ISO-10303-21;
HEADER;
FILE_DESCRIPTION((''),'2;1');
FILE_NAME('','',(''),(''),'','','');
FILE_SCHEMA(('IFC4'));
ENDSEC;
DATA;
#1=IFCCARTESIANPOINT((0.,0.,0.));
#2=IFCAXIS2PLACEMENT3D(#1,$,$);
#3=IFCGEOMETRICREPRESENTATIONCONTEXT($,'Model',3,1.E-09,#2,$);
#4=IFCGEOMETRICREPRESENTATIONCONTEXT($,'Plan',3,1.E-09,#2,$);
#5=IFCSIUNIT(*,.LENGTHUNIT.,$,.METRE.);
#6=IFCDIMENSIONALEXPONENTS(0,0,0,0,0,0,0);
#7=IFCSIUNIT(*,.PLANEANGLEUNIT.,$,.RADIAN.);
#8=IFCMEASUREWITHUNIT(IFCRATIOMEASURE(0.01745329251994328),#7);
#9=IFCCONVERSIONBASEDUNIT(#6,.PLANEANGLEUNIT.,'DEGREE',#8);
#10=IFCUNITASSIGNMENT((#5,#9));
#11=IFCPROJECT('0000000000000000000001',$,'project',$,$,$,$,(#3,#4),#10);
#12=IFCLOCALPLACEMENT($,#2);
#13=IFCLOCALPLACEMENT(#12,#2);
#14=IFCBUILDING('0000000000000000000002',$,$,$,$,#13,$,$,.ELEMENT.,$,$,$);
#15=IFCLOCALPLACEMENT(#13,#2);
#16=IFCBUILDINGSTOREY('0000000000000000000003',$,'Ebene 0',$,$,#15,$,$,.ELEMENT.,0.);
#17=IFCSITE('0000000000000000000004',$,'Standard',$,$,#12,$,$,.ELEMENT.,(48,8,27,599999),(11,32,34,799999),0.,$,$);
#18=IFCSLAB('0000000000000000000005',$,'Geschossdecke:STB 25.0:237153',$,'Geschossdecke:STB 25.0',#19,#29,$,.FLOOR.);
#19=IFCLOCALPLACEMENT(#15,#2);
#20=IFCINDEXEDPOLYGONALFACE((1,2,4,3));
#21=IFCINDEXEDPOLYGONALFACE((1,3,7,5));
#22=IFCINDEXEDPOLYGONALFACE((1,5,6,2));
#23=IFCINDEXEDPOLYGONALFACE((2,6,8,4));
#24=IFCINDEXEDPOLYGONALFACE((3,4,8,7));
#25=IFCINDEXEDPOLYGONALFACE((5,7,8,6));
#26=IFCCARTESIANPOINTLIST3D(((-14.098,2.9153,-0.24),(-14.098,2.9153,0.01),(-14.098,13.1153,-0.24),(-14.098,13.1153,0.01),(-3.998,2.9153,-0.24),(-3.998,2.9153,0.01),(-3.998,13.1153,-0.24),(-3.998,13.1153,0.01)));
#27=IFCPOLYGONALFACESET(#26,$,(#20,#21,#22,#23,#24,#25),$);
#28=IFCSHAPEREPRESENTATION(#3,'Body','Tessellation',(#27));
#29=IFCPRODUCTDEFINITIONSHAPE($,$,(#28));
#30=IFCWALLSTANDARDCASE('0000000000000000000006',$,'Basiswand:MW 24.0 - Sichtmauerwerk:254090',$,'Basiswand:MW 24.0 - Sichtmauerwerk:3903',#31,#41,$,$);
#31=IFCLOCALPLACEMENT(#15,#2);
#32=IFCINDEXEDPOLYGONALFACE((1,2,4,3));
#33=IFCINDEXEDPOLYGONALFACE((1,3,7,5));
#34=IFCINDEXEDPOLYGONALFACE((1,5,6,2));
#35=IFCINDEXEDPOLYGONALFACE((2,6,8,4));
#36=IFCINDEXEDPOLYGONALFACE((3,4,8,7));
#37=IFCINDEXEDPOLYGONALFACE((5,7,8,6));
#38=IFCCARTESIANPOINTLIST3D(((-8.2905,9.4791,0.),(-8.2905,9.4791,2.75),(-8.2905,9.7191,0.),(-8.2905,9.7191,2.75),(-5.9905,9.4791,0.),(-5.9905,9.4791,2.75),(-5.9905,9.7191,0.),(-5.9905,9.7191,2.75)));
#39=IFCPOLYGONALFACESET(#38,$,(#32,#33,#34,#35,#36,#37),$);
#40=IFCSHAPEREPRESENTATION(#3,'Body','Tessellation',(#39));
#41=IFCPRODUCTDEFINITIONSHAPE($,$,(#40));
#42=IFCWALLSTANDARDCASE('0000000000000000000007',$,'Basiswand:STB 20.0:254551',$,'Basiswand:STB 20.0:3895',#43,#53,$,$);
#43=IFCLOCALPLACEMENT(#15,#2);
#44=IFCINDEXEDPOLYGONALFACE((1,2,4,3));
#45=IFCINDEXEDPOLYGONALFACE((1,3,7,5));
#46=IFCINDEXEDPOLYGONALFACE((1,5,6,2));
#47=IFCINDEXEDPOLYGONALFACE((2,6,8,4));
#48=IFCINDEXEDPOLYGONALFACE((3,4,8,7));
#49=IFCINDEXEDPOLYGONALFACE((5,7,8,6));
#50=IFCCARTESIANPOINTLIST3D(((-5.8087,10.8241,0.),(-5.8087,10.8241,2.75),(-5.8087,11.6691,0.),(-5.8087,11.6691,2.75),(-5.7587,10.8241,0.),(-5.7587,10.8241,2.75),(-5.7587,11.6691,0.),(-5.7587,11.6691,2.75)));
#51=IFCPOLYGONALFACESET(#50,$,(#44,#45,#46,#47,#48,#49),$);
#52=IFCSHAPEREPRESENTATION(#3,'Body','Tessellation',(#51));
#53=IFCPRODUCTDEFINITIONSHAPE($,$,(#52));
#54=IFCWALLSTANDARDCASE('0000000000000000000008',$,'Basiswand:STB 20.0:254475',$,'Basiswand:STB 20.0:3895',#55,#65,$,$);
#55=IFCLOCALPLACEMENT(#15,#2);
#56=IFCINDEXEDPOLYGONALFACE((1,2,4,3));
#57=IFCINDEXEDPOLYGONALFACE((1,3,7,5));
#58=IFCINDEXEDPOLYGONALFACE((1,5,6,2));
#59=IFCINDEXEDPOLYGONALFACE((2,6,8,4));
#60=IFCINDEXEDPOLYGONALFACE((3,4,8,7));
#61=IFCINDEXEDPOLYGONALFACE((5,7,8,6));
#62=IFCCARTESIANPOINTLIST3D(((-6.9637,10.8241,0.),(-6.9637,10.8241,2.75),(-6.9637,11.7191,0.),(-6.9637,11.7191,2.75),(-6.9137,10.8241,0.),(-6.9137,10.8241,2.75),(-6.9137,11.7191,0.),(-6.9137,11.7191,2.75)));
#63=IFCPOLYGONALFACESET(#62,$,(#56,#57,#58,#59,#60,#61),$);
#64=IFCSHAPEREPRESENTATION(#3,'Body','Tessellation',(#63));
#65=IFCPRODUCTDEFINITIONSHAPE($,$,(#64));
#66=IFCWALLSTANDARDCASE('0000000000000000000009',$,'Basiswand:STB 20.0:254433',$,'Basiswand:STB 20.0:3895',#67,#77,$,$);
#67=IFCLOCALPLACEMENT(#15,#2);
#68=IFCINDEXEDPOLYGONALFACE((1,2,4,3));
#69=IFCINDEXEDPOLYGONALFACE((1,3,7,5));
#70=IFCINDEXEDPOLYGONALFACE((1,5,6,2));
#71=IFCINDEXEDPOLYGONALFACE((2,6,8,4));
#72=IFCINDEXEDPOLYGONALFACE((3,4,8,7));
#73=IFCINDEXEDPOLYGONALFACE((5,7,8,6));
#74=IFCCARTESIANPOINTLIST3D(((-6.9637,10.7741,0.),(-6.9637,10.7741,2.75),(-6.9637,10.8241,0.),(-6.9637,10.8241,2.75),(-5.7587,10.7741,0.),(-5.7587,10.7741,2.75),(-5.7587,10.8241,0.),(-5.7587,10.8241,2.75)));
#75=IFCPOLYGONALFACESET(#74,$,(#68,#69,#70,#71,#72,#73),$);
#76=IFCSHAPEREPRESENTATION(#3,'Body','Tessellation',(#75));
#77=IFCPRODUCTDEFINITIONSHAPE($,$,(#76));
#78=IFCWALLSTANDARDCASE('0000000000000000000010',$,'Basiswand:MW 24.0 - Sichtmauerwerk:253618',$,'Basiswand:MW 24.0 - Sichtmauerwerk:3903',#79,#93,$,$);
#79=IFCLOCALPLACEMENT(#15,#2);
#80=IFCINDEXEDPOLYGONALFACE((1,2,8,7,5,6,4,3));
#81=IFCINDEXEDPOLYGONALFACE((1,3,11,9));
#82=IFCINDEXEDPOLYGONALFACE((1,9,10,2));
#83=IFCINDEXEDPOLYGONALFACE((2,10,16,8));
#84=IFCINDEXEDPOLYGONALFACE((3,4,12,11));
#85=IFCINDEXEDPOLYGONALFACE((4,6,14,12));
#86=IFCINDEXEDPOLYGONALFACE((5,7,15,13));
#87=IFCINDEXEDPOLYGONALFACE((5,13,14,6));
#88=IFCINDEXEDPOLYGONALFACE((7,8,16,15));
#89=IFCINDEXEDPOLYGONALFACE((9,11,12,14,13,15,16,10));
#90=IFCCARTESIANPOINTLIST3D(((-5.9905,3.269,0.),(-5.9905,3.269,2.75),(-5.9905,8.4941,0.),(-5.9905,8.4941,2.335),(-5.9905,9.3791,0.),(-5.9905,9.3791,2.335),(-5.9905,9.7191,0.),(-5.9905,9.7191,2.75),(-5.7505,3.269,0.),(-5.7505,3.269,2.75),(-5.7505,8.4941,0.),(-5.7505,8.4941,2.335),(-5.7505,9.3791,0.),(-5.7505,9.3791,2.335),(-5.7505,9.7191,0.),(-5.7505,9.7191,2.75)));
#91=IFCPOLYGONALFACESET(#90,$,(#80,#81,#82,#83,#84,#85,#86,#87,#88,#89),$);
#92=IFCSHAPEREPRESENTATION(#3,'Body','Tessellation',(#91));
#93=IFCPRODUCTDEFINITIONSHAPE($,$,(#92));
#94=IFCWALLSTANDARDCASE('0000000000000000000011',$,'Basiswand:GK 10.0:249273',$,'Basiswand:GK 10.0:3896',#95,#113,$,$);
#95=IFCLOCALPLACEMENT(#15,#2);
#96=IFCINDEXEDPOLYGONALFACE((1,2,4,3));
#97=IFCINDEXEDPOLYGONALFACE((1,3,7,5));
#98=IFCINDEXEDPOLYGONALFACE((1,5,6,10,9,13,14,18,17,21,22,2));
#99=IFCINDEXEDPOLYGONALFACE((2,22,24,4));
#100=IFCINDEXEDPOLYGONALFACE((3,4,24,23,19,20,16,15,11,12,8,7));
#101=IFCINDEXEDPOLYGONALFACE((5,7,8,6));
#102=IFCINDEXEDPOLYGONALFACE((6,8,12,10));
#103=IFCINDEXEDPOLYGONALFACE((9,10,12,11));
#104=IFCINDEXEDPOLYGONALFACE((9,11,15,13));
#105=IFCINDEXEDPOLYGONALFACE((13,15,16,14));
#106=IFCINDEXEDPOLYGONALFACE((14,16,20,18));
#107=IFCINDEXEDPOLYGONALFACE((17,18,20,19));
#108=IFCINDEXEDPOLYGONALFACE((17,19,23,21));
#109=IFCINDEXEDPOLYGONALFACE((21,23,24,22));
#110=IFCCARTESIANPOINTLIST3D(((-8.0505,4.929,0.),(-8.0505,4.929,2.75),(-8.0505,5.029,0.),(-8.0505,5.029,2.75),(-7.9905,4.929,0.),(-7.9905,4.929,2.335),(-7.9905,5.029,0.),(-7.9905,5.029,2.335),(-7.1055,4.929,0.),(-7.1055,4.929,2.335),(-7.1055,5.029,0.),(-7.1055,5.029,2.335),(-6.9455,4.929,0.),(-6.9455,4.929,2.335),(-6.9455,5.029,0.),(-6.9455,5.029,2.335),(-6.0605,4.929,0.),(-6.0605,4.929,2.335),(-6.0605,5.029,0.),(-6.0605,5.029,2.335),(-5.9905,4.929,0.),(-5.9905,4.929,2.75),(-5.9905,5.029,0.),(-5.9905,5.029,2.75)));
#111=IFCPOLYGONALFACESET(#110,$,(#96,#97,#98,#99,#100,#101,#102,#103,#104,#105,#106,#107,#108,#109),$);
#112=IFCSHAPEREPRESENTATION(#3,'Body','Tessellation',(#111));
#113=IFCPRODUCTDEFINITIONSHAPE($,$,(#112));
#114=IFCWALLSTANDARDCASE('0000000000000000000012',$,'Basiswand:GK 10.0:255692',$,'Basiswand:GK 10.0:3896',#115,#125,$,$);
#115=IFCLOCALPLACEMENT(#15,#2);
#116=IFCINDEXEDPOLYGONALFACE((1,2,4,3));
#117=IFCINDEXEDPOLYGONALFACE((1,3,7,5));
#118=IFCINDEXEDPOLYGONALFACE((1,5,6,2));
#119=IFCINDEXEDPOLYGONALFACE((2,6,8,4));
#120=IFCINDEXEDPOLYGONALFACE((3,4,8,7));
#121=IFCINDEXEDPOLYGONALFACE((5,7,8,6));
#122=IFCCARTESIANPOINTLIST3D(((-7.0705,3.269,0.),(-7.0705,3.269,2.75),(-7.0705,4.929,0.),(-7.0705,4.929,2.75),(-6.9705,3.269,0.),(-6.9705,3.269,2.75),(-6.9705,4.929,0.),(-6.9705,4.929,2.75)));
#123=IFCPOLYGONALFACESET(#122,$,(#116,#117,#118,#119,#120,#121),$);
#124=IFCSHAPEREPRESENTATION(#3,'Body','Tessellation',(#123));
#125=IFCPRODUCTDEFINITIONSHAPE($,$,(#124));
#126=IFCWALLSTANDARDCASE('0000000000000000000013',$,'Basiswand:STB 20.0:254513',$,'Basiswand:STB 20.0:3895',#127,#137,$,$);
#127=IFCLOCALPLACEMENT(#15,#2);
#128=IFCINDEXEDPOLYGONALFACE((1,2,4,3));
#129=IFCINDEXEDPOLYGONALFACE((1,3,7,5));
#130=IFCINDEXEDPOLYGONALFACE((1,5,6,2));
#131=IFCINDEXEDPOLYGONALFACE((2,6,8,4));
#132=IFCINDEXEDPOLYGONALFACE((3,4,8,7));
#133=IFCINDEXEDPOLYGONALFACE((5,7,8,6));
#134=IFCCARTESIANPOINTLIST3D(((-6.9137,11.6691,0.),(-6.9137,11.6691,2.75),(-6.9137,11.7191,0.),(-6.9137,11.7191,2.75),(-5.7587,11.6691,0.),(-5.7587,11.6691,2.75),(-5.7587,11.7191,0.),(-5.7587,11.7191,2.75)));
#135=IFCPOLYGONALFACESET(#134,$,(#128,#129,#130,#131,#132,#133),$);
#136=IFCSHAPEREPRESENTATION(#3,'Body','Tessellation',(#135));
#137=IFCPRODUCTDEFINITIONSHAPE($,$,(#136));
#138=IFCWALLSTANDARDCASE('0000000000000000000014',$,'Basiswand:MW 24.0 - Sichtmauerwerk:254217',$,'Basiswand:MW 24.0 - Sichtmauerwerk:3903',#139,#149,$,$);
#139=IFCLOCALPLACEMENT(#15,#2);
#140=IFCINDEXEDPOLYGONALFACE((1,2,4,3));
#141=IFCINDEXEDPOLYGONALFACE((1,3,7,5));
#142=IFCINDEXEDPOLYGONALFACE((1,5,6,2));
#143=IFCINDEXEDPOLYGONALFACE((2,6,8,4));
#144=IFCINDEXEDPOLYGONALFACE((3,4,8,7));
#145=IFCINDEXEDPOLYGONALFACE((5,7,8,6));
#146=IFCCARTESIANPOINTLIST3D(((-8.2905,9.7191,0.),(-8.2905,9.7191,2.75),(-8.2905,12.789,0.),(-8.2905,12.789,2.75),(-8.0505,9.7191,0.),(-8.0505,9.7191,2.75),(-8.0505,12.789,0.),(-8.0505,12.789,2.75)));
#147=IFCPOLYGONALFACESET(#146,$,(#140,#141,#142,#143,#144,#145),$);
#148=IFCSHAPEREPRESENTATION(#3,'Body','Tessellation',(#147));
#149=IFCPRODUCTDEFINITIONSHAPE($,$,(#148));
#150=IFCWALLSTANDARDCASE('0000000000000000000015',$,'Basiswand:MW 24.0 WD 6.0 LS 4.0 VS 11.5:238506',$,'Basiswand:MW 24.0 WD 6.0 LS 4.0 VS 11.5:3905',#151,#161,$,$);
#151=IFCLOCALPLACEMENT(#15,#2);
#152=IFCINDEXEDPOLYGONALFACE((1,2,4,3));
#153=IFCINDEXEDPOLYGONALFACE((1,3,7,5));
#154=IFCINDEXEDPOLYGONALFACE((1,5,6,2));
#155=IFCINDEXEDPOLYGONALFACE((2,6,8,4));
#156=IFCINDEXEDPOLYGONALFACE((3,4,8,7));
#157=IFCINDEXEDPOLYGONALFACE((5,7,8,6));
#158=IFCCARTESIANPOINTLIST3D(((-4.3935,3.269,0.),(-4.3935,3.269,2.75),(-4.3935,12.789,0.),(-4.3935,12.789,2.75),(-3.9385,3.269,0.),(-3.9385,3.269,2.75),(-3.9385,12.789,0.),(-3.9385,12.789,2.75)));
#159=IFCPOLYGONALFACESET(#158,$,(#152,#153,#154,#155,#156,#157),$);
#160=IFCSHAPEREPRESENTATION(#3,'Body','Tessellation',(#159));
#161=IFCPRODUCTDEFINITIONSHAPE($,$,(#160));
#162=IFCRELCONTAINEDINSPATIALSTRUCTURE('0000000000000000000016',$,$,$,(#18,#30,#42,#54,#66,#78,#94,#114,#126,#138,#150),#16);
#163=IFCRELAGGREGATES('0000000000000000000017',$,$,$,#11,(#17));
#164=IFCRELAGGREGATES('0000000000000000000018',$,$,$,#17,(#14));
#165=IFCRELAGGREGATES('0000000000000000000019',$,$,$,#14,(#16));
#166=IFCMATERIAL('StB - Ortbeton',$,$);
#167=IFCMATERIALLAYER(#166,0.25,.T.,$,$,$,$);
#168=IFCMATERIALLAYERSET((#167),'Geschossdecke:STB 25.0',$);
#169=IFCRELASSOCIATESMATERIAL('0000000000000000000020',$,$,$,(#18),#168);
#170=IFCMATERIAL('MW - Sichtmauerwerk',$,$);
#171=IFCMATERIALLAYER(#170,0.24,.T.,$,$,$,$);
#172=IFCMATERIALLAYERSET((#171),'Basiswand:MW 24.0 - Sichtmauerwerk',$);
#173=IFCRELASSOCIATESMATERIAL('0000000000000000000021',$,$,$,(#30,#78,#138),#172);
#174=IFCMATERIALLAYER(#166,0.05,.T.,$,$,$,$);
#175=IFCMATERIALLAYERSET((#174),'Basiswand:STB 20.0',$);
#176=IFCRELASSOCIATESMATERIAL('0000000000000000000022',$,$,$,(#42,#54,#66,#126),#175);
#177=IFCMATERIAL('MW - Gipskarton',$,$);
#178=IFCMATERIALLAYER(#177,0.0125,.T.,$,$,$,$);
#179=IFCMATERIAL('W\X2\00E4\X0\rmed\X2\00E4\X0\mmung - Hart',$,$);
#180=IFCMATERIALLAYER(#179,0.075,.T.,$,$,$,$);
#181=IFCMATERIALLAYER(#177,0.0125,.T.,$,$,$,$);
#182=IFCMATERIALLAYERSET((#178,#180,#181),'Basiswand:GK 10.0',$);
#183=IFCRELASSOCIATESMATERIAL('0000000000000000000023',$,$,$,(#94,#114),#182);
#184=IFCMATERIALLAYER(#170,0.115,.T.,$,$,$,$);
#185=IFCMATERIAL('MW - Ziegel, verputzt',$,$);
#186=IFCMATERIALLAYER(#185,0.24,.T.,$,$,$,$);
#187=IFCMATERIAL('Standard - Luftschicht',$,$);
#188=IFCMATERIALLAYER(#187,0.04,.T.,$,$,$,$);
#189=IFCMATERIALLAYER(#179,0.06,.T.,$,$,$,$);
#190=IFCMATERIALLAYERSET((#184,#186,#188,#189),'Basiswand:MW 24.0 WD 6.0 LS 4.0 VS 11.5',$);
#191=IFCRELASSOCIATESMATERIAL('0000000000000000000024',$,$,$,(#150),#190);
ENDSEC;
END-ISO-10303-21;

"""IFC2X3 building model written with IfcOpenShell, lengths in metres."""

from ifc_helpers import new_model, entity, si_unit, converted_unit, frame, frame_2d, origin, place, context, project, spatial, rectangle, extrude, material, layer, layer_set, layer_usage, element, save


model = new_model("IFC2X3")

# Units and contexts
model_context = context("Model", 3, precision=1e-09, world=origin())
plan_context = context("Plan", 3, precision=1e-09, world=origin())
ifc_project = project(units=[si_unit("LENGTHUNIT", "METRE"), converted_unit("PLANEANGLEUNIT", "DEGREE", entity("IfcRatioMeasure", 0.01745329251994328), si_unit("PLANEANGLEUNIT", "RADIAN"), dimensions=[0, 0, 0, 0, 0, 0, 0])], contexts=[model_context, plan_context])

# Site, building, storey
site_placement = place(None, origin())
site = spatial("IfcSite", under=ifc_project, at=site_placement, Name="Standard", CompositionType="ELEMENT", RefLatitude=(48, 8, 27, 599999), RefLongitude=(11, 32, 34, 799999), RefElevation=0.0)
building_placement = place(site_placement, origin())
building = spatial("IfcBuilding", under=site, at=building_placement, CompositionType="ELEMENT")
storey_placement = place(building_placement, origin())
storey = spatial("IfcBuildingStorey", under=building, at=storey_placement, Name="Ebene 0", CompositionType="ELEMENT", Elevation=0.0)

# Slab
ifc_material_1 = material(Name="StB - Ortbeton")
ifc_layer_1 = layer(ifc_material_1, 0.25, ventilated=True)
ifc_layer_set_1 = layer_set([ifc_layer_1], Name="Geschossdecke:STB 25.0")
ifc_layer_usage_1 = layer_usage(ifc_layer_set_1, "AXIS3", "POSITIVE", 0.0)
slab_placement = place(storey_placement, frame((-14.098, 2.9153, -0.24)))
element("IfcSlab", 1, at=slab_placement, inside=storey, material=ifc_layer_usage_1, Name="Geschossdecke:STB 25.0:237153", ObjectType="Geschossdecke:STB 25.0", PredefinedType="FLOOR", context=model_context, shape_type="SweptSolid", body=[
    extrude(rectangle(XDim=10.2, YDim=10.1, at=frame_2d((0.0, 0.0), x_axis=(0.0, -1.0))), frame((5.05, 5.1, 0.25), z_axis=(0.0, 0.0, -1.0), x_axis=(-1.0, 0.0, 0.0)), (0.0, 0.0, 1.0), 0.25),
])

# Walls
ifc_material_2 = material(Name="MW - Sichtmauerwerk")
ifc_layer_2 = layer(ifc_material_2, 0.24, ventilated=True)
ifc_layer_set_2 = layer_set([ifc_layer_2], Name="Basiswand:MW 24.0 - Sichtmauerwerk")
ifc_layer_usage_2 = layer_usage(ifc_layer_set_2, "AXIS2", "NEGATIVE", 0.12)
wall_1_placement = place(storey_placement, frame((-5.9905, 9.5991, 0.0), z_axis=(0.0, 0.0, 1.0), x_axis=(-1.0, 0.0, 0.0)))
element("IfcWallStandardCase", 2, at=wall_1_placement, inside=storey, material=ifc_layer_usage_2, Name="Basiswand:MW 24.0 - Sichtmauerwerk:254090", ObjectType="Basiswand:MW 24.0 - Sichtmauerwerk:3903", context=model_context, shape_type="SweptSolid", body=[
    extrude(rectangle(XDim=2.3, YDim=0.24, at=frame_2d((1.15, 0.0), x_axis=(-1.0, 0.0))), origin(), (0.0, 0.0, 1.0), 2.75),
])
ifc_layer_3 = layer(ifc_material_1, 0.05, ventilated=True)
ifc_layer_set_3 = layer_set([ifc_layer_3], Name="Basiswand:STB 20.0")
ifc_layer_usage_3 = layer_usage(ifc_layer_set_3, "AXIS2", "NEGATIVE", 0.025)
wall_2_placement = place(storey_placement, frame((-5.7837, 11.6691, 0.0), z_axis=(0.0, 0.0, 1.0), x_axis=(0.0, -1.0, 0.0)))
element("IfcWallStandardCase", 3, at=wall_2_placement, inside=storey, material=ifc_layer_usage_3, Name="Basiswand:STB 20.0:254551", ObjectType="Basiswand:STB 20.0:3895", context=model_context, shape_type="SweptSolid", body=[
    extrude(rectangle(XDim=0.845, YDim=0.05, at=frame_2d((0.4225, 0.0), x_axis=(-1.0, 0.0))), origin(), (0.0, 0.0, 1.0), 2.75),
])
ifc_layer_usage_4 = layer_usage(ifc_layer_set_3, "AXIS2", "NEGATIVE", 0.025)
wall_3_placement = place(storey_placement, frame((-6.9387, 10.8241, 0.0), z_axis=(0.0, 0.0, 1.0), x_axis=(0.0, 1.0, 0.0)))
element("IfcWallStandardCase", 4, at=wall_3_placement, inside=storey, material=ifc_layer_usage_4, Name="Basiswand:STB 20.0:254475", ObjectType="Basiswand:STB 20.0:3895", context=model_context, shape_type="SweptSolid", body=[
    extrude(rectangle(XDim=0.895, YDim=0.05, at=frame_2d((0.4475, 0.0), x_axis=(-1.0, 0.0))), origin(), (0.0, 0.0, 1.0), 2.75),
])
ifc_layer_usage_5 = layer_usage(ifc_layer_set_3, "AXIS2", "NEGATIVE", 0.025)
wall_4_placement = place(storey_placement, frame((-5.7587, 10.7991, 0.0), z_axis=(0.0, 0.0, 1.0), x_axis=(-1.0, 0.0, 0.0)))
element("IfcWallStandardCase", 5, at=wall_4_placement, inside=storey, material=ifc_layer_usage_5, Name="Basiswand:STB 20.0:254433", ObjectType="Basiswand:STB 20.0:3895", context=model_context, shape_type="SweptSolid", body=[
    extrude(rectangle(XDim=1.205, YDim=0.05, at=frame_2d((0.6025, 0.0), x_axis=(-1.0, 0.0))), origin(), (0.0, 0.0, 1.0), 2.75),
])

# Wall, opening
ifc_layer_usage_6 = layer_usage(ifc_layer_set_2, "AXIS2", "NEGATIVE", 0.12)
wall_5_placement = place(storey_placement, frame((-5.8705, 9.7191, 0.0), z_axis=(0.0, 0.0, 1.0), x_axis=(0.0, -1.0, 0.0)))
wall_5 = element("IfcWallStandardCase", 6, at=wall_5_placement, inside=storey, material=ifc_layer_usage_6, Name="Basiswand:MW 24.0 - Sichtmauerwerk:253618", ObjectType="Basiswand:MW 24.0 - Sichtmauerwerk:3903", context=model_context, shape_type="SweptSolid", body=[
    extrude(rectangle(XDim=6.4501, YDim=0.24, at=frame_2d((3.225, 0.0), x_axis=(-1.0, 0.0))), origin(), (0.0, 0.0, 1.0), 2.75),
])
opening_1_placement = place(wall_5_placement, frame((1.225, 0.12, 0.0)))
element("IfcOpeningElement", 7, at=opening_1_placement, cuts=wall_5, ObjectType="Opening", context=model_context, shape_type="SweptSolid", body=[
    extrude(rectangle(XDim=2.335, YDim=0.885, at=frame_2d((1.1675, 0.4425), x_axis=(1.0, 0.0))), frame((0.0, 0.0, 0.0), z_axis=(0.0, -1.0, 0.0), x_axis=(0.0, 0.0, 1.0)), (0.0, 0.0, 1.0), 0.24),
])

# Wall, openings
ifc_material_3 = material(Name="MW - Gipskarton")
ifc_layer_4 = layer(ifc_material_3, 0.0125, ventilated=True)
ifc_material_4 = material(Name="Wärmedämmung - Hart")
ifc_layer_5 = layer(ifc_material_4, 0.075, ventilated=True)
ifc_layer_6 = layer(ifc_material_3, 0.0125, ventilated=True)
ifc_layer_set_4 = layer_set([ifc_layer_4, ifc_layer_5, ifc_layer_6], Name="Basiswand:GK 10.0")
ifc_layer_usage_7 = layer_usage(ifc_layer_set_4, "AXIS2", "NEGATIVE", 0.05)
wall_6_placement = place(storey_placement, frame((-5.9905, 4.979, 0.0), z_axis=(0.0, 0.0, 1.0), x_axis=(-1.0, 0.0, 0.0)))
wall_6 = element("IfcWallStandardCase", 8, at=wall_6_placement, inside=storey, material=ifc_layer_usage_7, Name="Basiswand:GK 10.0:249273", ObjectType="Basiswand:GK 10.0:3896", context=model_context, shape_type="SweptSolid", body=[
    extrude(rectangle(XDim=2.06, YDim=0.1, at=frame_2d((1.03, 0.0), x_axis=(-1.0, 0.0))), origin(), (0.0, 0.0, 1.0), 2.75),
])
opening_2_placement = place(wall_6_placement, frame((2.0, 0.05, 0.0)))
element("IfcOpeningElement", 9, at=opening_2_placement, cuts=wall_6, ObjectType="Opening", context=model_context, shape_type="SweptSolid", body=[
    extrude(rectangle(XDim=2.335, YDim=0.885, at=frame_2d((1.1675, 0.4425), x_axis=(1.0, 0.0))), frame((0.0, 0.0, 0.0), z_axis=(0.0, -1.0, 0.0), x_axis=(0.0, 0.0, 1.0)), (0.0, 0.0, 1.0), 0.1),
])
opening_3_placement = place(wall_6_placement, frame((0.955, 0.05, 0.0)))
element("IfcOpeningElement", 10, at=opening_3_placement, cuts=wall_6, ObjectType="Opening", context=model_context, shape_type="SweptSolid", body=[
    extrude(rectangle(XDim=2.335, YDim=0.885, at=frame_2d((1.1675, 0.4425), x_axis=(1.0, 0.0))), frame((0.0, 0.0, 0.0), z_axis=(0.0, -1.0, 0.0), x_axis=(0.0, 0.0, 1.0)), (0.0, 0.0, 1.0), 0.1),
])

# Wall
ifc_layer_usage_8 = layer_usage(ifc_layer_set_4, "AXIS2", "NEGATIVE", 0.05)
wall_7_placement = place(storey_placement, frame((-7.0205, 4.929, 0.0), z_axis=(0.0, 0.0, 1.0), x_axis=(0.0, -1.0, 0.0)))
element("IfcWallStandardCase", 11, at=wall_7_placement, inside=storey, material=ifc_layer_usage_8, Name="Basiswand:GK 10.0:255692", ObjectType="Basiswand:GK 10.0:3896", context=model_context, shape_type="SweptSolid", body=[
    extrude(rectangle(XDim=1.66, YDim=0.1, at=frame_2d((0.83, 0.0), x_axis=(-1.0, 0.0))), origin(), (0.0, 0.0, 1.0), 2.75),
])

# Shared definitions
ifc_layer_7 = layer(ifc_material_2, 0.115, ventilated=True)
ifc_material_5 = material(Name="MW - Ziegel, verputzt")
ifc_layer_8 = layer(ifc_material_5, 0.24, ventilated=True)
ifc_material_6 = material(Name="Standard - Luftschicht")
ifc_layer_9 = layer(ifc_material_6, 0.04, ventilated=True)
ifc_layer_10 = layer(ifc_material_4, 0.06, ventilated=True)
ifc_layer_set_5 = layer_set([ifc_layer_7, ifc_layer_8, ifc_layer_9, ifc_layer_10], Name="Basiswand:MW 24.0 WD 6.0 LS 4.0 VS 11.5")

# Walls
ifc_layer_usage_9 = layer_usage(ifc_layer_set_3, "AXIS2", "NEGATIVE", 0.025)
wall_8_placement = place(storey_placement, frame((-6.9137, 11.6941, 0.0)))
element("IfcWallStandardCase", 12, at=wall_8_placement, inside=storey, material=ifc_layer_usage_9, Name="Basiswand:STB 20.0:254513", ObjectType="Basiswand:STB 20.0:3895", context=model_context, shape_type="SweptSolid", body=[
    extrude(rectangle(XDim=1.155, YDim=0.05, at=frame_2d((0.5775, 0.0), x_axis=(-1.0, 0.0))), origin(), (0.0, 0.0, 1.0), 2.75),
])
ifc_layer_usage_10 = layer_usage(ifc_layer_set_2, "AXIS2", "NEGATIVE", 0.12)
wall_9_placement = place(storey_placement, frame((-8.1705, 9.7191, 0.0), z_axis=(0.0, 0.0, 1.0), x_axis=(0.0, 1.0, 0.0)))
element("IfcWallStandardCase", 13, at=wall_9_placement, inside=storey, material=ifc_layer_usage_10, Name="Basiswand:MW 24.0 - Sichtmauerwerk:254217", ObjectType="Basiswand:MW 24.0 - Sichtmauerwerk:3903", context=model_context, shape_type="SweptSolid", body=[
    extrude(rectangle(XDim=3.0699, YDim=0.24, at=frame_2d((1.535, 0.0), x_axis=(-1.0, 0.0))), origin(), (0.0, 0.0, 1.0), 2.75),
])
ifc_layer_usage_11 = layer_usage(ifc_layer_set_5, "AXIS2", "NEGATIVE", 0.2275)
wall_10_placement = place(storey_placement, frame((-4.166, 12.789, 0.0), z_axis=(0.0, 0.0, 1.0), x_axis=(0.0, -1.0, 0.0)))
element("IfcWallStandardCase", 14, at=wall_10_placement, inside=storey, material=ifc_layer_usage_11, Name="Basiswand:MW 24.0 WD 6.0 LS 4.0 VS 11.5:238506", ObjectType="Basiswand:MW 24.0 WD 6.0 LS 4.0 VS 11.5:3905", context=model_context, shape_type="SweptSolid", body=[
    extrude(rectangle(XDim=9.52, YDim=0.455, at=frame_2d((4.76, 0.0), x_axis=(-1.0, 0.0))), origin(), (0.0, 0.0, 1.0), 2.75),
])

save(model, "model.ifc")
